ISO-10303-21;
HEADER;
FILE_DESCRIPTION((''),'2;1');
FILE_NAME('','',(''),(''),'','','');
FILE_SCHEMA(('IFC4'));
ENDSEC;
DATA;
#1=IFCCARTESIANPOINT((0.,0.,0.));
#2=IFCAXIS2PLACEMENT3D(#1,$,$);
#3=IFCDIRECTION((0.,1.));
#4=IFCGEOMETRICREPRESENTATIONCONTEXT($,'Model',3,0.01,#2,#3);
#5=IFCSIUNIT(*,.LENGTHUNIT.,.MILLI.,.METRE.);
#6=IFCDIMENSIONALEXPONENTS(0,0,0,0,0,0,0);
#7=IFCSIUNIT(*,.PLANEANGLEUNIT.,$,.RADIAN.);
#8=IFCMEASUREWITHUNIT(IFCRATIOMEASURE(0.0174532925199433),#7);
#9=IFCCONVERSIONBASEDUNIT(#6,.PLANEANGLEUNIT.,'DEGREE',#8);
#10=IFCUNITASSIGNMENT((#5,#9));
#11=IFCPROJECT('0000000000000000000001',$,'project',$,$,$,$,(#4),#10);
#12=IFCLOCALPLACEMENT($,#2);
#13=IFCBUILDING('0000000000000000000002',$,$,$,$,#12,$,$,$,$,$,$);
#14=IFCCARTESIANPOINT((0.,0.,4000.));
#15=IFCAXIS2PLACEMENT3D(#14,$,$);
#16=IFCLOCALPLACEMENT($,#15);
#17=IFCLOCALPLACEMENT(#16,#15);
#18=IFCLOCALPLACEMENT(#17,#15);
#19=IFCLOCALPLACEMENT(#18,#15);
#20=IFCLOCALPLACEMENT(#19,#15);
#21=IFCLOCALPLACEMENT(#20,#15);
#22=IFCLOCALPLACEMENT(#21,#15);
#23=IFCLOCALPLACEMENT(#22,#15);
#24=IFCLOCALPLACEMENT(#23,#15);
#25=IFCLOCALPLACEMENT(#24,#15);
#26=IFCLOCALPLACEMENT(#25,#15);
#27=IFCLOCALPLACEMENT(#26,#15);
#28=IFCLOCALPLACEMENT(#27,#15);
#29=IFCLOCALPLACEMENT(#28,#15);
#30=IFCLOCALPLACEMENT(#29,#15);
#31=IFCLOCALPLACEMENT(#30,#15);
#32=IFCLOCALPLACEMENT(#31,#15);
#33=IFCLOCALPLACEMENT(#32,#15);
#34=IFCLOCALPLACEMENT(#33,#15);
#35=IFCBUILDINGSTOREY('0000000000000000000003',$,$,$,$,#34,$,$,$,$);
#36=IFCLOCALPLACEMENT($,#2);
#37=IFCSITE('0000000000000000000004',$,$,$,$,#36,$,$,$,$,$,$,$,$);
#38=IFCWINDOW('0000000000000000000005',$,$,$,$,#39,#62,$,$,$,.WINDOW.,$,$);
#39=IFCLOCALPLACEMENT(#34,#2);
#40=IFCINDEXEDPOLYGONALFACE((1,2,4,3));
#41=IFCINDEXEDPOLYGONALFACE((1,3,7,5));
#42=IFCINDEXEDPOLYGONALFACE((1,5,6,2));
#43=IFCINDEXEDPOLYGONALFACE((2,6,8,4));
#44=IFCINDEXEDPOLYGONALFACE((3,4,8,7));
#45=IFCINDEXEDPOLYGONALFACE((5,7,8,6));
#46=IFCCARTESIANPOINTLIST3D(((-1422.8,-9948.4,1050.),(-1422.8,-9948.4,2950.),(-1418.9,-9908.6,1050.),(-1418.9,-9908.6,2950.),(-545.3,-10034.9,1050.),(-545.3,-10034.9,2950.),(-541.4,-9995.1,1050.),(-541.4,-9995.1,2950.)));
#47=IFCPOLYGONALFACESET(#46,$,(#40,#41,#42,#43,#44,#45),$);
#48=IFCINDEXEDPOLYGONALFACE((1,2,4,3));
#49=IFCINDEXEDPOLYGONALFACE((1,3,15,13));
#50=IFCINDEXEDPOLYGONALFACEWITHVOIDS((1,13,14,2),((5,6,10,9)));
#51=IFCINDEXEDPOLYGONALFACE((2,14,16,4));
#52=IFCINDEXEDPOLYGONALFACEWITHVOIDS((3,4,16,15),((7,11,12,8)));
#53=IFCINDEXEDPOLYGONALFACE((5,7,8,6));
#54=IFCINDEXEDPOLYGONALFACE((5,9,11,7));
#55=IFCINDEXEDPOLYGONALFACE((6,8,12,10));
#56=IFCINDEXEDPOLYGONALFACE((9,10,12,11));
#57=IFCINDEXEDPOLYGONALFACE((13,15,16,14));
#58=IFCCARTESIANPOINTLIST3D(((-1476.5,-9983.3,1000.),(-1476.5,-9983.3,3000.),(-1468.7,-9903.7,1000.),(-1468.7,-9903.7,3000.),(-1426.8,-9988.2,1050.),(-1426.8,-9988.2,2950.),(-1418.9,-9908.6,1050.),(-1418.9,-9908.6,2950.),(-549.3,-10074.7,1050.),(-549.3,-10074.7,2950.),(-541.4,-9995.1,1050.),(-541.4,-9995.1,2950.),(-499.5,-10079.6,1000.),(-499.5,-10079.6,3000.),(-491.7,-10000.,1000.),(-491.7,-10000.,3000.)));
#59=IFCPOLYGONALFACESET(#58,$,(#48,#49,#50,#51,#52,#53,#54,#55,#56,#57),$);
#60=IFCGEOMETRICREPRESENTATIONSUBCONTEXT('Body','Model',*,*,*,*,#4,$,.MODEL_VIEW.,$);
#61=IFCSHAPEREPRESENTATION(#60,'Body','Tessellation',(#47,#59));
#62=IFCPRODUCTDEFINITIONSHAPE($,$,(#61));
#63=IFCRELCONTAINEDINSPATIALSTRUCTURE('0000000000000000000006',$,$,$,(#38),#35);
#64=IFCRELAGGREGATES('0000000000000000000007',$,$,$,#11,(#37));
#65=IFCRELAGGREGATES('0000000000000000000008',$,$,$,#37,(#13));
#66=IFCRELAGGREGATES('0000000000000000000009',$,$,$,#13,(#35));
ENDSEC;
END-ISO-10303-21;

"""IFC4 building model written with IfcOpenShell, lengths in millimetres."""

from ifc_helpers import new_model, entity, si_unit, converted_unit, direction, frame, origin, place, context, subcontext, project, spatial, element, save


model = new_model("IFC4")

# Units and contexts
model_context = context("Model", 3, precision=0.01, world=origin(), true_north=direction((0.0, 1.0)))
body_context = subcontext(model_context, "Body", "Model", "MODEL_VIEW")
ifc_project = project(units=[si_unit("LENGTHUNIT", "METRE", prefix="MILLI"), converted_unit("PLANEANGLEUNIT", "DEGREE", entity("IfcRatioMeasure", 0.0174532925199433), si_unit("PLANEANGLEUNIT", "RADIAN"), dimensions=[0, 0, 0, 0, 0, 0, 0])], contexts=[model_context])

# Site, building, storey
site_placement = place(None, origin())
site = spatial("IfcSite", under=ifc_project, at=site_placement)
building_placement = place(None, origin())
building = spatial("IfcBuilding", under=site, at=building_placement)
placement_1 = place(None, frame((0.0, 0.0, 4000.0)))
placement_2 = place(placement_1, frame((0.0, 0.0, 4000.0)))
placement_3 = place(placement_2, frame((0.0, 0.0, 4000.0)))
placement_4 = place(placement_3, frame((0.0, 0.0, 4000.0)))
placement_5 = place(placement_4, frame((0.0, 0.0, 4000.0)))
placement_6 = place(placement_5, frame((0.0, 0.0, 4000.0)))
placement_7 = place(placement_6, frame((0.0, 0.0, 4000.0)))
placement_8 = place(placement_7, frame((0.0, 0.0, 4000.0)))
placement_9 = place(placement_8, frame((0.0, 0.0, 4000.0)))
placement_10 = place(placement_9, frame((0.0, 0.0, 4000.0)))
placement_11 = place(placement_10, frame((0.0, 0.0, 4000.0)))
placement_12 = place(placement_11, frame((0.0, 0.0, 4000.0)))
placement_13 = place(placement_12, frame((0.0, 0.0, 4000.0)))
placement_14 = place(placement_13, frame((0.0, 0.0, 4000.0)))
placement_15 = place(placement_14, frame((0.0, 0.0, 4000.0)))
placement_16 = place(placement_15, frame((0.0, 0.0, 4000.0)))
placement_17 = place(placement_16, frame((0.0, 0.0, 4000.0)))
placement_18 = place(placement_17, frame((0.0, 0.0, 4000.0)))
storey_placement = place(placement_18, frame((0.0, 0.0, 4000.0)))
storey = spatial("IfcBuildingStorey", under=building, at=storey_placement)

# Shared definitions
cartesian_point_1 = entity("IfcCartesianPoint", [-440.9, -950.0])
shared_polyline = entity("IfcPolyline", [cartesian_point_1, entity("IfcCartesianPoint", [-440.9, 950.0]), entity("IfcCartesianPoint", [-440.9, 950.0]), entity("IfcCartesianPoint", [440.9, 950.0]), entity("IfcCartesianPoint", [440.9, 950.0]), entity("IfcCartesianPoint", [440.9, -950.0]), entity("IfcCartesianPoint", [440.9, -950.0]), entity("IfcCartesianPoint", [-440.9, -950.0]), cartesian_point_1])

# Window
window_1_placement = place(storey_placement, frame((-980.2, -9951.8, 2000.0), z_axis=(0.0, 0.0, 1.0), x_axis=(9951.847473, -980.16931, 0.0)))
cartesian_point_2 = entity("IfcCartesianPoint", [-490.9, -1000.0])
element("IfcWindow", 1, at=window_1_placement, inside=storey, PredefinedType="WINDOW", context=body_context, shape_type="SweptSolid", body=[
    entity("IfcExtrudedAreaSolid", entity("IfcArbitraryClosedProfileDef", "AREA", None, shared_polyline), entity("IfcAxis2Placement3D", entity("IfcCartesianPoint", [0.0, 0.0, 0.0]), entity("IfcDirection", [0.0, -1.0, 0.0]), entity("IfcDirection", [1.0, 0.0, 0.0])), entity("IfcDirection", [0.0, 0.0, 1.0]), 40.0),
    entity("IfcExtrudedAreaSolid", entity("IfcArbitraryProfileDefWithVoids", "AREA", None, entity("IfcPolyline", [cartesian_point_2, entity("IfcCartesianPoint", [-490.9, 1000.0]), entity("IfcCartesianPoint", [-490.9, 1000.0]), entity("IfcCartesianPoint", [490.9, 1000.0]), entity("IfcCartesianPoint", [490.9, 1000.0]), entity("IfcCartesianPoint", [490.9, -1000.0]), entity("IfcCartesianPoint", [490.9, -1000.0]), entity("IfcCartesianPoint", [-490.9, -1000.0]), cartesian_point_2]), [shared_polyline]), entity("IfcAxis2Placement3D", entity("IfcCartesianPoint", [0.0, 0.0, 0.0]), entity("IfcDirection", [0.0, -1.0, 0.0]), entity("IfcDirection", [1.0, 0.0, 0.0])), entity("IfcDirection", [0.0, 0.0, 1.0]), 80.0),
])

save(model, "model.ifc")
